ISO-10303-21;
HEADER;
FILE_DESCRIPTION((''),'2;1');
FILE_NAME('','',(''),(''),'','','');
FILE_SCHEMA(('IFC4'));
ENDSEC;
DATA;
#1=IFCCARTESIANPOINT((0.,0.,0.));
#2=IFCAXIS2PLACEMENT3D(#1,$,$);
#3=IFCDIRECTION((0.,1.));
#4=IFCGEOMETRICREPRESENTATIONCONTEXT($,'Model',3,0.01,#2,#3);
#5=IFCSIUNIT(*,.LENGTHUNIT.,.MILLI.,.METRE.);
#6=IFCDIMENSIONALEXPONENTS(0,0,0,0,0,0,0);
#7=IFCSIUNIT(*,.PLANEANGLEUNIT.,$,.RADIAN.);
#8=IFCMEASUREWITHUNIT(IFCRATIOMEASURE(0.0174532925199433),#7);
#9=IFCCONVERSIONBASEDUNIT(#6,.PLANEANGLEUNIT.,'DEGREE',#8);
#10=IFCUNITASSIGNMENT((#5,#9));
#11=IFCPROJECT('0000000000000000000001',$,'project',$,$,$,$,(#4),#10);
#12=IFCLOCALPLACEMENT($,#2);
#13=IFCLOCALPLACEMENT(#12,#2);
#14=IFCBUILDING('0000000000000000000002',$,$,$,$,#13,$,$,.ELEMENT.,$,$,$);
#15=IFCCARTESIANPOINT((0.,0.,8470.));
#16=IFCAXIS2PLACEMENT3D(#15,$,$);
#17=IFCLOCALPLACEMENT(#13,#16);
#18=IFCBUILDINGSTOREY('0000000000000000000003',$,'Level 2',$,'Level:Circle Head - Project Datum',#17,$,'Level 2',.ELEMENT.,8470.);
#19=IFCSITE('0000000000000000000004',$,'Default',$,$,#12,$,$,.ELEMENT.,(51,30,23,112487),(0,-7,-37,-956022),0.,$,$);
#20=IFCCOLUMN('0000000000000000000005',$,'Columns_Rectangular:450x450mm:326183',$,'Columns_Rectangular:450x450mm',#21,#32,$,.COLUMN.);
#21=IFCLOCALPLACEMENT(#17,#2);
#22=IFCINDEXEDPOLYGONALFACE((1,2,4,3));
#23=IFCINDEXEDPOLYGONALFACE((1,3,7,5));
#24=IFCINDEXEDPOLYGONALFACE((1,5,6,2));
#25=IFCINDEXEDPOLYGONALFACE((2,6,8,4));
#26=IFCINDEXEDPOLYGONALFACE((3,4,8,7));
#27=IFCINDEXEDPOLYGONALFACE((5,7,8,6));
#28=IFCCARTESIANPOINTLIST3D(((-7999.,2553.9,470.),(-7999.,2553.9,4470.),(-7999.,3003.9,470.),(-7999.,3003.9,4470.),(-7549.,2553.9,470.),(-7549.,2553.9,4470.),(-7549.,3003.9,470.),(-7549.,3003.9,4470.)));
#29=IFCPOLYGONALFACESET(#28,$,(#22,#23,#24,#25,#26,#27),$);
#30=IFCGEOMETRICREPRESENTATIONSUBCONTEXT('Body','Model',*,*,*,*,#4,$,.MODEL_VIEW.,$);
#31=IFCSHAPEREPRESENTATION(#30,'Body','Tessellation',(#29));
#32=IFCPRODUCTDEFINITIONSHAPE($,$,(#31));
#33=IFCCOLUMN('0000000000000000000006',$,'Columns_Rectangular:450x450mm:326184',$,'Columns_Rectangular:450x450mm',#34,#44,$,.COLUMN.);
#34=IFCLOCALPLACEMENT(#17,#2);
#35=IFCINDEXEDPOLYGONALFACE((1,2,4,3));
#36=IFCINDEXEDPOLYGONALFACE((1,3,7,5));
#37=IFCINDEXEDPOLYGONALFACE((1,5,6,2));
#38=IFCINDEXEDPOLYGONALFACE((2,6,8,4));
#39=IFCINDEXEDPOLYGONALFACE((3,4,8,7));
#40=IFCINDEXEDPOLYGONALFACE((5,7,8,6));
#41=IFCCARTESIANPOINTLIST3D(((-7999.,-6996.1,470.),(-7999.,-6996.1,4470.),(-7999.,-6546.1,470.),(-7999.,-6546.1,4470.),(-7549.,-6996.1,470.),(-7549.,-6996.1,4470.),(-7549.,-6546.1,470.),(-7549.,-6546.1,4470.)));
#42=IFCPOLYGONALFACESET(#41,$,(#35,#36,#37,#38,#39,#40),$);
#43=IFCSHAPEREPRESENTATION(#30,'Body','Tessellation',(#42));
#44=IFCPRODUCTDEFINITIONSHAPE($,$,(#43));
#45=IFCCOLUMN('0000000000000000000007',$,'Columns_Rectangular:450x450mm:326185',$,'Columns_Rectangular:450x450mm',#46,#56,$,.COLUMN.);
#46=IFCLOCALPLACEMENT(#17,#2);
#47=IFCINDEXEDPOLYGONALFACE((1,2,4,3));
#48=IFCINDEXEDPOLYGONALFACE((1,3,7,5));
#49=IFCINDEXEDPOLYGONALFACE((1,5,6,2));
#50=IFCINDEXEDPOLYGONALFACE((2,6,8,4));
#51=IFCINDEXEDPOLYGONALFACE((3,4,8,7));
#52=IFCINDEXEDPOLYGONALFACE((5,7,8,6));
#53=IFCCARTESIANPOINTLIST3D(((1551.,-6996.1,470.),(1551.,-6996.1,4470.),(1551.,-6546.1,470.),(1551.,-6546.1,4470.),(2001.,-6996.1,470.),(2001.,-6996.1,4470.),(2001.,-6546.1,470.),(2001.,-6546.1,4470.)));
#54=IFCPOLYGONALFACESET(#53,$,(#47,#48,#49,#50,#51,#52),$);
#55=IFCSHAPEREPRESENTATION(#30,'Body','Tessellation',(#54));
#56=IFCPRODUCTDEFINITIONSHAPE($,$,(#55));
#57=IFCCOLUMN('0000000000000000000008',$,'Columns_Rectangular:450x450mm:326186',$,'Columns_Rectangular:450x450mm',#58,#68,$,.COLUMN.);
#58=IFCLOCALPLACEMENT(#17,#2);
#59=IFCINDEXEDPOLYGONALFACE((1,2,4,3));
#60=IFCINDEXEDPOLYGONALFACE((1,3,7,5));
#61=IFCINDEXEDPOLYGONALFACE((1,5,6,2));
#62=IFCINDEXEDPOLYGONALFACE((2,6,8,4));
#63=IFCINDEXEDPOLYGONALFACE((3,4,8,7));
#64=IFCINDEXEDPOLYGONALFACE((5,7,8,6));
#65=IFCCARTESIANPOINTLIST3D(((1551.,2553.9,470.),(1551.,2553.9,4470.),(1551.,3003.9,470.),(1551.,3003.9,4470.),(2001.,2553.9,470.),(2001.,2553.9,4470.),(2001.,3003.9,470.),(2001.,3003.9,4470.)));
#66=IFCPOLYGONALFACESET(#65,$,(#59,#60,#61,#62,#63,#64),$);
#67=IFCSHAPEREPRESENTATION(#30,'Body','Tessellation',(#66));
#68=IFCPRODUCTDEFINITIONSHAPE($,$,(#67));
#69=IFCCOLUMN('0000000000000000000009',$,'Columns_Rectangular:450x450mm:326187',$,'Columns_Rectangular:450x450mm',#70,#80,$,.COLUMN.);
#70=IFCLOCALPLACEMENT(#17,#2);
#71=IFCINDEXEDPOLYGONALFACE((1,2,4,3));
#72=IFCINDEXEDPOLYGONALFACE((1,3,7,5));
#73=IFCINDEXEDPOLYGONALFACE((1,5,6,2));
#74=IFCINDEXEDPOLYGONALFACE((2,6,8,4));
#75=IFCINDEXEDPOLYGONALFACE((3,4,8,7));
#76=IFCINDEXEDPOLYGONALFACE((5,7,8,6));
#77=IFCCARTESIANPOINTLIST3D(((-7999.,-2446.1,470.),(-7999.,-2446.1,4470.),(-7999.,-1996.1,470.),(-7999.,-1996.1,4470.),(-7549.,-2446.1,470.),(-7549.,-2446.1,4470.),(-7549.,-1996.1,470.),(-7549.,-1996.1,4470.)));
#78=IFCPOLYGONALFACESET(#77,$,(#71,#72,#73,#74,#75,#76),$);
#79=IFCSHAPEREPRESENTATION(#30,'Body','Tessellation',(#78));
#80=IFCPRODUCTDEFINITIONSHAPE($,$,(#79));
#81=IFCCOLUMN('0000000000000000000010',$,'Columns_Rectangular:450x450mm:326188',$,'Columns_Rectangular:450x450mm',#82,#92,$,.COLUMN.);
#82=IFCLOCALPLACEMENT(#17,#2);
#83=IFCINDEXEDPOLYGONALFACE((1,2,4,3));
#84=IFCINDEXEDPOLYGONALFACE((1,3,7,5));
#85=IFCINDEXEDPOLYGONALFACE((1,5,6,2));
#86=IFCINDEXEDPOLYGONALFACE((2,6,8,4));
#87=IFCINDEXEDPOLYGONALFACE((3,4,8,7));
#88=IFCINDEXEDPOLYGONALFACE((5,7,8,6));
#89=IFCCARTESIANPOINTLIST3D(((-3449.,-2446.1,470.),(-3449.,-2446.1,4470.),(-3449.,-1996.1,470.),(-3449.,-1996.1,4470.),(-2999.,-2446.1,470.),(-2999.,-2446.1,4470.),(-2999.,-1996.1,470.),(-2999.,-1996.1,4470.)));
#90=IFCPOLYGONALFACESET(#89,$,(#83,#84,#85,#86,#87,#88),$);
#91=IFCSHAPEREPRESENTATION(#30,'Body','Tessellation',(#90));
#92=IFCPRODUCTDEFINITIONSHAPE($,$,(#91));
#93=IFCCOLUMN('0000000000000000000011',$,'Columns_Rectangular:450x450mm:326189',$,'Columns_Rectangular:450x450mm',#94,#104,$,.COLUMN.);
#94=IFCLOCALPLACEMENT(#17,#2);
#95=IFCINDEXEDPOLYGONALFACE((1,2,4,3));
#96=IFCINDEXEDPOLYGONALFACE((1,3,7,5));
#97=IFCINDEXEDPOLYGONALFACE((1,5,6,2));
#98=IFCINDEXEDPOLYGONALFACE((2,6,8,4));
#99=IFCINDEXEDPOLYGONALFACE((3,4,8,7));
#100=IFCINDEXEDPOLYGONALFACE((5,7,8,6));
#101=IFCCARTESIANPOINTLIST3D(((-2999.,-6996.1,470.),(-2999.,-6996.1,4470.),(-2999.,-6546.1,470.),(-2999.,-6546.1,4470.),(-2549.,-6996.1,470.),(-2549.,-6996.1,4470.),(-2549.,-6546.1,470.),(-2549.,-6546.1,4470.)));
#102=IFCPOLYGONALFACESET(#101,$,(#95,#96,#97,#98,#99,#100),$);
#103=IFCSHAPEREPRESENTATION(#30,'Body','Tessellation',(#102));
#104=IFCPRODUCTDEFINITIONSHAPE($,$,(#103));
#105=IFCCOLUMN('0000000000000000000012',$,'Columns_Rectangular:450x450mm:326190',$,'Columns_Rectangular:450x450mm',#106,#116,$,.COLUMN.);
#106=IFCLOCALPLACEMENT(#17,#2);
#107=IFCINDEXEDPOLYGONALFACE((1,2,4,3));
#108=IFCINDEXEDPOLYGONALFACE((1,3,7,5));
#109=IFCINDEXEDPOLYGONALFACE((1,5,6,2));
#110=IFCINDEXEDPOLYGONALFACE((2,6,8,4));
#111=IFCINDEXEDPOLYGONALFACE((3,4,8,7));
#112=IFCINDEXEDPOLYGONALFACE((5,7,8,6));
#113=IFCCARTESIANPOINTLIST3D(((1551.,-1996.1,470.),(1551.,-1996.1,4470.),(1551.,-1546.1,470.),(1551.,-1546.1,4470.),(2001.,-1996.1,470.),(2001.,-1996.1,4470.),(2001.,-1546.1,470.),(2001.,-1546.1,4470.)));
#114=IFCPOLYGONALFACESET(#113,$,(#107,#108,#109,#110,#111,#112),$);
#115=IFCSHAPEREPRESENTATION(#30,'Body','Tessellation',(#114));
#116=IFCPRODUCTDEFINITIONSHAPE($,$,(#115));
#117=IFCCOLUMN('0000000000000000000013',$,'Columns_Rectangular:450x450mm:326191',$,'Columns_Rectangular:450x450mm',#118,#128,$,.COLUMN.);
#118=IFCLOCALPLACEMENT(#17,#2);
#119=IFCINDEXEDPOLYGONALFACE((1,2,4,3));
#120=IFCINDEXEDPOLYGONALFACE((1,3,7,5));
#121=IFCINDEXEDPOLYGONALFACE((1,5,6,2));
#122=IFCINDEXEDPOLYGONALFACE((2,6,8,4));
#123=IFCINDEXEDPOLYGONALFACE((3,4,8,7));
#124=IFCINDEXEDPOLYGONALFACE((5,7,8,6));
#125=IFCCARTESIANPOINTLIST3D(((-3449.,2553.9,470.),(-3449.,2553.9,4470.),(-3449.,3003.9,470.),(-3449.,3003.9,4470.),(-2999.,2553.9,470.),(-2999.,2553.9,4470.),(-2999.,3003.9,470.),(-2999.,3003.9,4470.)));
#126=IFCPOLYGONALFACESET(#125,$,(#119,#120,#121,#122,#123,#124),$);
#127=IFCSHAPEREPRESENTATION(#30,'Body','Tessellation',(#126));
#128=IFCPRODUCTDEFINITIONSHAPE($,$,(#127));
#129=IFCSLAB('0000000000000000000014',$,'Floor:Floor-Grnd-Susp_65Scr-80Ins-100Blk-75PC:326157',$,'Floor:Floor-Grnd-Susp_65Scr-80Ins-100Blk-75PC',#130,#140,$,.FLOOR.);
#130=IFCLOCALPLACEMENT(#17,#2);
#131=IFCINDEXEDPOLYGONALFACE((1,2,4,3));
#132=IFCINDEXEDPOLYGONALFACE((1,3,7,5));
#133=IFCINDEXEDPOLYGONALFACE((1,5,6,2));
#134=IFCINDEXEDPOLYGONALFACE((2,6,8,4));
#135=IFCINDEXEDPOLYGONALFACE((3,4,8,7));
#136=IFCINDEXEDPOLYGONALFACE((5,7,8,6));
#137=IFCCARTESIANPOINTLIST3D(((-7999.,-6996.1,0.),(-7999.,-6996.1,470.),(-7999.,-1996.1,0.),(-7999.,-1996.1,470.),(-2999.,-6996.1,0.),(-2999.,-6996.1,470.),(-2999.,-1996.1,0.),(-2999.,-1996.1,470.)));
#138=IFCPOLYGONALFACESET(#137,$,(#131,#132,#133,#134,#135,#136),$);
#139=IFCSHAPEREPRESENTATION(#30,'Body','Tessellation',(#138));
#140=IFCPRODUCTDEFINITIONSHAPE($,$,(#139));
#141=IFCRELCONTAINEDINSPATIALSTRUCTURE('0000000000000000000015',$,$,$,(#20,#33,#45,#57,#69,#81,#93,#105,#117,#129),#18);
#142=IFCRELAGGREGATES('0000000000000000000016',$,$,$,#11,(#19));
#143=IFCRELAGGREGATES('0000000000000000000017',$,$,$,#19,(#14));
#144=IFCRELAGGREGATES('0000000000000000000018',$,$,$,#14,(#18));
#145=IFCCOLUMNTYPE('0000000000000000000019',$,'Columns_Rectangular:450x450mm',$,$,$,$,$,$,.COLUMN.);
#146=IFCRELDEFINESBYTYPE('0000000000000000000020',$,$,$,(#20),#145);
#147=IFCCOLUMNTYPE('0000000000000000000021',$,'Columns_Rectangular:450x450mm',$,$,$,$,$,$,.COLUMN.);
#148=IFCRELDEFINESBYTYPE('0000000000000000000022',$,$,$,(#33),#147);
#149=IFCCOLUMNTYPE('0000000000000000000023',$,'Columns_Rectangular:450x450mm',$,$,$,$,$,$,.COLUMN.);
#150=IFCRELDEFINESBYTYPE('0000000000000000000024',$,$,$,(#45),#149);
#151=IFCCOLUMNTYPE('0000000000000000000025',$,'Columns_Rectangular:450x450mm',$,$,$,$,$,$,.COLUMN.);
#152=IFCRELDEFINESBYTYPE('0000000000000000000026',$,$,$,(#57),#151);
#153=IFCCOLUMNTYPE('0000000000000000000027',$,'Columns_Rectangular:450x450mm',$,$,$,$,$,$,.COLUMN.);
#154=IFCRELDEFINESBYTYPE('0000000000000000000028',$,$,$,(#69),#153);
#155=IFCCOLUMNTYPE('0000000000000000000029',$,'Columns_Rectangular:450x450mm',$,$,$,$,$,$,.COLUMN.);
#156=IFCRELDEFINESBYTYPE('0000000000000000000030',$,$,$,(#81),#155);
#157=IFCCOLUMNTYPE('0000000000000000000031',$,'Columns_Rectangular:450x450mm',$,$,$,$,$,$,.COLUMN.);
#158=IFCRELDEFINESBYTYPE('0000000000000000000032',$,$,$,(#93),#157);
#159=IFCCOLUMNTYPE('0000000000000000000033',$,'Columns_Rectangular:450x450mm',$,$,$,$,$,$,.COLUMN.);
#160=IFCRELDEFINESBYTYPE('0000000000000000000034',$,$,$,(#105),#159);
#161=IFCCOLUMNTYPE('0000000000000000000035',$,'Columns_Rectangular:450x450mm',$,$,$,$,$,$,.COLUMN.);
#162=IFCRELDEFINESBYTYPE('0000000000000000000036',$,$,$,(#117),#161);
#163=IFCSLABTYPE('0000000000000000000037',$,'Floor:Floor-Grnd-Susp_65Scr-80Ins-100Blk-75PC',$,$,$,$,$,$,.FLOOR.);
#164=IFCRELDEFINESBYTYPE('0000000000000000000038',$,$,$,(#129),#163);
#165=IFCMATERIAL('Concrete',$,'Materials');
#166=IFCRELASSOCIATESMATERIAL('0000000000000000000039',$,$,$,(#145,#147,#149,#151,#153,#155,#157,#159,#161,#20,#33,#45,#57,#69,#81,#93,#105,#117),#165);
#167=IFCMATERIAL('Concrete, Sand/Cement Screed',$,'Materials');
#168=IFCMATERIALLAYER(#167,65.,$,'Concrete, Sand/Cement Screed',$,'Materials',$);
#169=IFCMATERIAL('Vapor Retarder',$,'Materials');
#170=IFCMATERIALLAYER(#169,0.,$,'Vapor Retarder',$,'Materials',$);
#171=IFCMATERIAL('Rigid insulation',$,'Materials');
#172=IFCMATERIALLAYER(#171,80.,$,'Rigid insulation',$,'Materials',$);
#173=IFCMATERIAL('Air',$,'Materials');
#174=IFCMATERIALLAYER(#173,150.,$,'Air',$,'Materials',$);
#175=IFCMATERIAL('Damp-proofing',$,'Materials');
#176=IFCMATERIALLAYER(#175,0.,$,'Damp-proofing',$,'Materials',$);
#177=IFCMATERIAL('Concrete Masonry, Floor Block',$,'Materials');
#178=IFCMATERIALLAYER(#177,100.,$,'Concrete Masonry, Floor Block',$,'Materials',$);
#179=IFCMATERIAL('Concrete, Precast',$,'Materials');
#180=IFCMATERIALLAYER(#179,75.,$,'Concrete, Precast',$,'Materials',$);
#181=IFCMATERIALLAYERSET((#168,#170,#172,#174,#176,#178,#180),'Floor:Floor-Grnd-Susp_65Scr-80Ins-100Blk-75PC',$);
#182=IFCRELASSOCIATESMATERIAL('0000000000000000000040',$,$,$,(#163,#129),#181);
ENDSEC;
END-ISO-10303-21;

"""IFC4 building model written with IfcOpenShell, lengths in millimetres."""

from ifc_helpers import new_model, entity, si_unit, converted_unit, direction, frame, frame_2d, origin, origin_2d_with_axis, place, context, subcontext, project, spatial, polyline, segment, composite_curve, rectangle, outline, extrude, source, transform, mapped, material, layer, layer_set, layer_usage, material_profile, profile_set, profile_usage, type_object, type_shapes, element, save


model = new_model("IFC4")

# Units and contexts
model_context = context("Model", 3, precision=0.01, world=origin(), true_north=direction((0.0, 1.0)))
body_context = subcontext(model_context, "Body", "Model", "MODEL_VIEW")
ifc_project = project(units=[si_unit("LENGTHUNIT", "METRE", prefix="MILLI"), converted_unit("PLANEANGLEUNIT", "DEGREE", entity("IfcRatioMeasure", 0.0174532925199433), si_unit("PLANEANGLEUNIT", "RADIAN"), dimensions=[0, 0, 0, 0, 0, 0, 0])], contexts=[model_context])

# Site, building, storey
site_placement = place(None, origin())
site = spatial("IfcSite", under=ifc_project, at=site_placement, Name="Default", CompositionType="ELEMENT", RefLatitude=(51, 30, 23, 112487), RefLongitude=(0, -7, -37, -956022), RefElevation=0.0)
building_placement = place(site_placement, origin())
building = spatial("IfcBuilding", under=site, at=building_placement, CompositionType="ELEMENT")
storey_placement = place(building_placement, frame((0.0, 0.0, 8470.0)))
storey = spatial("IfcBuildingStorey", under=building, at=storey_placement, Name="Level 2", ObjectType="Level:Circle Head - Project Datum", LongName="Level 2", CompositionType="ELEMENT", Elevation=8470.0)

# Columns
ifc_material_1 = material(Name="Concrete", Category="Materials")
ifc_material_profile = material_profile(ifc_material_1, outline(composite_curve([segment(polyline([(225.0, 225.0, 0.0), (225.0, -225.0, 0.0)]), True, "CONTINUOUS"), segment(polyline([(225.0, -225.0, 0.0), (-225.0, -225.0, 0.0)]), True, "CONTINUOUS"), segment(polyline([(-225.0, -225.0, 0.0), (-225.0, 225.0, 0.0)]), True, "CONTINUOUS"), segment(polyline([(-225.0, 225.0, 0.0), (225.0, 225.0, 0.0)]), True, "CONTINUOUS")], self_intersect=False), kind="CURVE"), Name="450x450mm")
ifc_profile_set = profile_set([ifc_material_profile], Name="450x450mm")
ifc_profile_usage_1 = profile_usage(ifc_profile_set)
column_type_1 = type_object("IfcColumnType", Name="Columns_Rectangular:450x450mm", PredefinedType="COLUMN", material=ifc_profile_set)
shared_shape_1 = source(origin(), body_context, "Body", "SweptSolid", [
    extrude(rectangle(XDim=450.0, YDim=450.0, at=frame_2d((0.0, 0.0), x_axis=(1.0, 0.0))), frame((-7774.0, 2778.9, 8940.0), z_axis=(0.0, 0.0, 1.0), x_axis=(0.0, -1.0, 0.0)), (0.0, 0.0, 1.0), 4000.0),
])
type_shapes(column_type_1, [shared_shape_1])
column_1_placement = place(storey_placement, frame((0.0, 0.0, -8470.0)))
element("IfcColumn", 1, at=column_1_placement, inside=storey, type_object=column_type_1, material=ifc_profile_usage_1, Name="Columns_Rectangular:450x450mm:326183", ObjectType="Columns_Rectangular:450x450mm", PredefinedType="COLUMN", context=body_context, shape_type="MappedRepresentation", body=[
    mapped(shared_shape_1, transform((0.0, 0.0, 0.0), scale=1.0)),
])
ifc_profile_usage_2 = profile_usage(ifc_profile_set)
column_type_2 = type_object("IfcColumnType", Name="Columns_Rectangular:450x450mm", PredefinedType="COLUMN", material=ifc_profile_set)
shared_shape_2 = source(origin(), body_context, "Body", "SweptSolid", [
    extrude(rectangle(XDim=450.0, YDim=450.0, at=frame_2d((0.0, 0.0), x_axis=(1.0, 0.0))), frame((-7774.0, -6771.1, 8940.0), z_axis=(0.0, 0.0, 1.0), x_axis=(0.0, -1.0, 0.0)), (0.0, 0.0, 1.0), 4000.0),
])
type_shapes(column_type_2, [shared_shape_2])
column_2_placement = place(storey_placement, frame((0.0, 0.0, -8470.0)))
element("IfcColumn", 2, at=column_2_placement, inside=storey, type_object=column_type_2, material=ifc_profile_usage_2, Name="Columns_Rectangular:450x450mm:326184", ObjectType="Columns_Rectangular:450x450mm", PredefinedType="COLUMN", context=body_context, shape_type="MappedRepresentation", body=[
    mapped(shared_shape_2, transform((0.0, 0.0, 0.0), scale=1.0)),
])
ifc_profile_usage_3 = profile_usage(ifc_profile_set)
column_type_3 = type_object("IfcColumnType", Name="Columns_Rectangular:450x450mm", PredefinedType="COLUMN", material=ifc_profile_set)
shared_shape_3 = source(origin(), body_context, "Body", "SweptSolid", [
    extrude(rectangle(XDim=450.0, YDim=450.0, at=frame_2d((0.0, 0.0), x_axis=(1.0, 0.0))), frame((1776.0, -6771.1, 8940.0), z_axis=(0.0, 0.0, 1.0), x_axis=(0.0, -1.0, 0.0)), (0.0, 0.0, 1.0), 4000.0),
])
type_shapes(column_type_3, [shared_shape_3])
column_3_placement = place(storey_placement, frame((0.0, 0.0, -8470.0)))
element("IfcColumn", 3, at=column_3_placement, inside=storey, type_object=column_type_3, material=ifc_profile_usage_3, Name="Columns_Rectangular:450x450mm:326185", ObjectType="Columns_Rectangular:450x450mm", PredefinedType="COLUMN", context=body_context, shape_type="MappedRepresentation", body=[
    mapped(shared_shape_3, transform((0.0, 0.0, 0.0), scale=1.0)),
])
ifc_profile_usage_4 = profile_usage(ifc_profile_set)
column_type_4 = type_object("IfcColumnType", Name="Columns_Rectangular:450x450mm", PredefinedType="COLUMN", material=ifc_profile_set)
shared_shape_4 = source(origin(), body_context, "Body", "SweptSolid", [
    extrude(rectangle(XDim=450.0, YDim=450.0, at=frame_2d((0.0, 0.0), x_axis=(1.0, 0.0))), frame((1776.0, 2778.9, 8940.0), z_axis=(0.0, 0.0, 1.0), x_axis=(0.0, -1.0, 0.0)), (0.0, 0.0, 1.0), 4000.0),
])
type_shapes(column_type_4, [shared_shape_4])
column_4_placement = place(storey_placement, frame((0.0, 0.0, -8470.0)))
element("IfcColumn", 4, at=column_4_placement, inside=storey, type_object=column_type_4, material=ifc_profile_usage_4, Name="Columns_Rectangular:450x450mm:326186", ObjectType="Columns_Rectangular:450x450mm", PredefinedType="COLUMN", context=body_context, shape_type="MappedRepresentation", body=[
    mapped(shared_shape_4, transform((0.0, 0.0, 0.0), scale=1.0)),
])
ifc_profile_usage_5 = profile_usage(ifc_profile_set)
column_type_5 = type_object("IfcColumnType", Name="Columns_Rectangular:450x450mm", PredefinedType="COLUMN", material=ifc_profile_set)
shared_shape_5 = source(origin(), body_context, "Body", "SweptSolid", [
    extrude(rectangle(XDim=450.0, YDim=450.0, at=frame_2d((0.0, 0.0), x_axis=(1.0, 0.0))), frame((-7774.0, -2221.1, 8940.0), z_axis=(0.0, 0.0, 1.0), x_axis=(0.0, -1.0, 0.0)), (0.0, 0.0, 1.0), 4000.0),
])
type_shapes(column_type_5, [shared_shape_5])
column_5_placement = place(storey_placement, frame((0.0, 0.0, -8470.0)))
element("IfcColumn", 5, at=column_5_placement, inside=storey, type_object=column_type_5, material=ifc_profile_usage_5, Name="Columns_Rectangular:450x450mm:326187", ObjectType="Columns_Rectangular:450x450mm", PredefinedType="COLUMN", context=body_context, shape_type="MappedRepresentation", body=[
    mapped(shared_shape_5, transform((0.0, 0.0, 0.0), scale=1.0)),
])
ifc_profile_usage_6 = profile_usage(ifc_profile_set)
column_type_6 = type_object("IfcColumnType", Name="Columns_Rectangular:450x450mm", PredefinedType="COLUMN", material=ifc_profile_set)
shared_shape_6 = source(origin(), body_context, "Body", "SweptSolid", [
    extrude(rectangle(XDim=450.0, YDim=450.0, at=origin_2d_with_axis()), frame((0.0, 0.0, 8940.0), z_axis=(0.0, 0.0, 1.0), x_axis=(0.0, -1.0, 0.0)), (0.0, 0.0, 1.0), 4000.0),
])
type_shapes(column_type_6, [shared_shape_6])
column_6_placement = place(storey_placement, frame((-3224.0, -2221.1, -8470.0)))
element("IfcColumn", 6, at=column_6_placement, inside=storey, type_object=column_type_6, material=ifc_profile_usage_6, Name="Columns_Rectangular:450x450mm:326188", ObjectType="Columns_Rectangular:450x450mm", PredefinedType="COLUMN", context=body_context, shape_type="MappedRepresentation", body=[
    mapped(shared_shape_6, transform((0.0, 0.0, 0.0), scale=1.0)),
])
ifc_profile_usage_7 = profile_usage(ifc_profile_set)
column_type_7 = type_object("IfcColumnType", Name="Columns_Rectangular:450x450mm", PredefinedType="COLUMN", material=ifc_profile_set)
shared_shape_7 = source(origin(), body_context, "Body", "SweptSolid", [
    extrude(rectangle(XDim=450.0, YDim=450.0, at=frame_2d((0.0, 0.0), x_axis=(1.0, 0.0))), frame((-2774.0, -6771.1, 8940.0), z_axis=(0.0, 0.0, 1.0), x_axis=(0.0, -1.0, 0.0)), (0.0, 0.0, 1.0), 4000.0),
])
type_shapes(column_type_7, [shared_shape_7])
column_7_placement = place(storey_placement, frame((0.0, 0.0, -8470.0)))
element("IfcColumn", 7, at=column_7_placement, inside=storey, type_object=column_type_7, material=ifc_profile_usage_7, Name="Columns_Rectangular:450x450mm:326189", ObjectType="Columns_Rectangular:450x450mm", PredefinedType="COLUMN", context=body_context, shape_type="MappedRepresentation", body=[
    mapped(shared_shape_7, transform((0.0, 0.0, 0.0), scale=1.0)),
])
ifc_profile_usage_8 = profile_usage(ifc_profile_set)
column_type_8 = type_object("IfcColumnType", Name="Columns_Rectangular:450x450mm", PredefinedType="COLUMN", material=ifc_profile_set)
shared_shape_8 = source(origin(), body_context, "Body", "SweptSolid", [
    extrude(rectangle(XDim=450.0, YDim=450.0, at=frame_2d((0.0, 0.0), x_axis=(1.0, 0.0))), frame((1776.0, -1771.1, 8940.0), z_axis=(0.0, 0.0, 1.0), x_axis=(0.0, -1.0, 0.0)), (0.0, 0.0, 1.0), 4000.0),
])
type_shapes(column_type_8, [shared_shape_8])
column_8_placement = place(storey_placement, frame((0.0, 0.0, -8470.0)))
element("IfcColumn", 8, at=column_8_placement, inside=storey, type_object=column_type_8, material=ifc_profile_usage_8, Name="Columns_Rectangular:450x450mm:326190", ObjectType="Columns_Rectangular:450x450mm", PredefinedType="COLUMN", context=body_context, shape_type="MappedRepresentation", body=[
    mapped(shared_shape_8, transform((0.0, 0.0, 0.0), scale=1.0)),
])
ifc_profile_usage_9 = profile_usage(ifc_profile_set)
column_type_9 = type_object("IfcColumnType", Name="Columns_Rectangular:450x450mm", PredefinedType="COLUMN", material=ifc_profile_set)
shared_shape_9 = source(origin(), body_context, "Body", "SweptSolid", [
    extrude(rectangle(XDim=450.0, YDim=450.0, at=frame_2d((0.0, 0.0), x_axis=(1.0, 0.0))), frame((-3224.0, 2778.9, 8940.0), z_axis=(0.0, 0.0, 1.0), x_axis=(0.0, -1.0, 0.0)), (0.0, 0.0, 1.0), 4000.0),
])
type_shapes(column_type_9, [shared_shape_9])
column_9_placement = place(storey_placement, frame((0.0, 0.0, -8470.0)))
element("IfcColumn", 9, at=column_9_placement, inside=storey, type_object=column_type_9, material=ifc_profile_usage_9, Name="Columns_Rectangular:450x450mm:326191", ObjectType="Columns_Rectangular:450x450mm", PredefinedType="COLUMN", context=body_context, shape_type="MappedRepresentation", body=[
    mapped(shared_shape_9, transform((0.0, 0.0, 0.0), scale=1.0)),
])

# Slab
ifc_material_2 = material(Name="Concrete, Sand/Cement Screed", Category="Materials")
ifc_layer_1 = layer(ifc_material_2, 65.0, Name="Concrete, Sand/Cement Screed", Category="Materials")
ifc_material_3 = material(Name="Vapor Retarder", Category="Materials")
ifc_layer_2 = layer(ifc_material_3, 0.0, Name="Vapor Retarder", Category="Materials")
ifc_material_4 = material(Name="Rigid insulation", Category="Materials")
ifc_layer_3 = layer(ifc_material_4, 80.0, Name="Rigid insulation", Category="Materials")
ifc_material_5 = material(Name="Air", Category="Materials")
ifc_layer_4 = layer(ifc_material_5, 150.0, Name="Air", Category="Materials")
ifc_material_6 = material(Name="Damp-proofing", Category="Materials")
ifc_layer_5 = layer(ifc_material_6, 0.0, Name="Damp-proofing", Category="Materials")
ifc_material_7 = material(Name="Concrete Masonry, Floor Block", Category="Materials")
ifc_layer_6 = layer(ifc_material_7, 100.0, Name="Concrete Masonry, Floor Block", Category="Materials")
ifc_material_8 = material(Name="Concrete, Precast", Category="Materials")
ifc_layer_7 = layer(ifc_material_8, 75.0, Name="Concrete, Precast", Category="Materials")
ifc_layer_set_1 = layer_set([ifc_layer_1, ifc_layer_2, ifc_layer_3, ifc_layer_4, ifc_layer_5, ifc_layer_6, ifc_layer_7], Name="Floor:Floor-Grnd-Susp_65Scr-80Ins-100Blk-75PC")
ifc_layer_usage_1 = layer_usage(ifc_layer_set_1, "AXIS3", "POSITIVE", 0.0)
slab_type_1 = type_object("IfcSlabType", Name="Floor:Floor-Grnd-Susp_65Scr-80Ins-100Blk-75PC", PredefinedType="FLOOR", material=ifc_layer_set_1)
slab_1_placement = place(storey_placement, origin())
element("IfcSlab", 10, at=slab_1_placement, inside=storey, type_object=slab_type_1, material=ifc_layer_usage_1, Name="Floor:Floor-Grnd-Susp_65Scr-80Ins-100Blk-75PC:326157", ObjectType="Floor:Floor-Grnd-Susp_65Scr-80Ins-100Blk-75PC", PredefinedType="FLOOR", context=body_context, shape_type="SweptSolid", body=[
    extrude(rectangle(XDim=5000.0, YDim=5000.0, at=frame_2d((0.0, 0.0), x_axis=(1.0, 0.0))), frame((-5499.0, -4496.1, 470.0), z_axis=(0.0, 0.0, -1.0), x_axis=(0.0, 1.0, 0.0)), (0.0, 0.0, 1.0), 470.0),
])

save(model, "model.ifc")
